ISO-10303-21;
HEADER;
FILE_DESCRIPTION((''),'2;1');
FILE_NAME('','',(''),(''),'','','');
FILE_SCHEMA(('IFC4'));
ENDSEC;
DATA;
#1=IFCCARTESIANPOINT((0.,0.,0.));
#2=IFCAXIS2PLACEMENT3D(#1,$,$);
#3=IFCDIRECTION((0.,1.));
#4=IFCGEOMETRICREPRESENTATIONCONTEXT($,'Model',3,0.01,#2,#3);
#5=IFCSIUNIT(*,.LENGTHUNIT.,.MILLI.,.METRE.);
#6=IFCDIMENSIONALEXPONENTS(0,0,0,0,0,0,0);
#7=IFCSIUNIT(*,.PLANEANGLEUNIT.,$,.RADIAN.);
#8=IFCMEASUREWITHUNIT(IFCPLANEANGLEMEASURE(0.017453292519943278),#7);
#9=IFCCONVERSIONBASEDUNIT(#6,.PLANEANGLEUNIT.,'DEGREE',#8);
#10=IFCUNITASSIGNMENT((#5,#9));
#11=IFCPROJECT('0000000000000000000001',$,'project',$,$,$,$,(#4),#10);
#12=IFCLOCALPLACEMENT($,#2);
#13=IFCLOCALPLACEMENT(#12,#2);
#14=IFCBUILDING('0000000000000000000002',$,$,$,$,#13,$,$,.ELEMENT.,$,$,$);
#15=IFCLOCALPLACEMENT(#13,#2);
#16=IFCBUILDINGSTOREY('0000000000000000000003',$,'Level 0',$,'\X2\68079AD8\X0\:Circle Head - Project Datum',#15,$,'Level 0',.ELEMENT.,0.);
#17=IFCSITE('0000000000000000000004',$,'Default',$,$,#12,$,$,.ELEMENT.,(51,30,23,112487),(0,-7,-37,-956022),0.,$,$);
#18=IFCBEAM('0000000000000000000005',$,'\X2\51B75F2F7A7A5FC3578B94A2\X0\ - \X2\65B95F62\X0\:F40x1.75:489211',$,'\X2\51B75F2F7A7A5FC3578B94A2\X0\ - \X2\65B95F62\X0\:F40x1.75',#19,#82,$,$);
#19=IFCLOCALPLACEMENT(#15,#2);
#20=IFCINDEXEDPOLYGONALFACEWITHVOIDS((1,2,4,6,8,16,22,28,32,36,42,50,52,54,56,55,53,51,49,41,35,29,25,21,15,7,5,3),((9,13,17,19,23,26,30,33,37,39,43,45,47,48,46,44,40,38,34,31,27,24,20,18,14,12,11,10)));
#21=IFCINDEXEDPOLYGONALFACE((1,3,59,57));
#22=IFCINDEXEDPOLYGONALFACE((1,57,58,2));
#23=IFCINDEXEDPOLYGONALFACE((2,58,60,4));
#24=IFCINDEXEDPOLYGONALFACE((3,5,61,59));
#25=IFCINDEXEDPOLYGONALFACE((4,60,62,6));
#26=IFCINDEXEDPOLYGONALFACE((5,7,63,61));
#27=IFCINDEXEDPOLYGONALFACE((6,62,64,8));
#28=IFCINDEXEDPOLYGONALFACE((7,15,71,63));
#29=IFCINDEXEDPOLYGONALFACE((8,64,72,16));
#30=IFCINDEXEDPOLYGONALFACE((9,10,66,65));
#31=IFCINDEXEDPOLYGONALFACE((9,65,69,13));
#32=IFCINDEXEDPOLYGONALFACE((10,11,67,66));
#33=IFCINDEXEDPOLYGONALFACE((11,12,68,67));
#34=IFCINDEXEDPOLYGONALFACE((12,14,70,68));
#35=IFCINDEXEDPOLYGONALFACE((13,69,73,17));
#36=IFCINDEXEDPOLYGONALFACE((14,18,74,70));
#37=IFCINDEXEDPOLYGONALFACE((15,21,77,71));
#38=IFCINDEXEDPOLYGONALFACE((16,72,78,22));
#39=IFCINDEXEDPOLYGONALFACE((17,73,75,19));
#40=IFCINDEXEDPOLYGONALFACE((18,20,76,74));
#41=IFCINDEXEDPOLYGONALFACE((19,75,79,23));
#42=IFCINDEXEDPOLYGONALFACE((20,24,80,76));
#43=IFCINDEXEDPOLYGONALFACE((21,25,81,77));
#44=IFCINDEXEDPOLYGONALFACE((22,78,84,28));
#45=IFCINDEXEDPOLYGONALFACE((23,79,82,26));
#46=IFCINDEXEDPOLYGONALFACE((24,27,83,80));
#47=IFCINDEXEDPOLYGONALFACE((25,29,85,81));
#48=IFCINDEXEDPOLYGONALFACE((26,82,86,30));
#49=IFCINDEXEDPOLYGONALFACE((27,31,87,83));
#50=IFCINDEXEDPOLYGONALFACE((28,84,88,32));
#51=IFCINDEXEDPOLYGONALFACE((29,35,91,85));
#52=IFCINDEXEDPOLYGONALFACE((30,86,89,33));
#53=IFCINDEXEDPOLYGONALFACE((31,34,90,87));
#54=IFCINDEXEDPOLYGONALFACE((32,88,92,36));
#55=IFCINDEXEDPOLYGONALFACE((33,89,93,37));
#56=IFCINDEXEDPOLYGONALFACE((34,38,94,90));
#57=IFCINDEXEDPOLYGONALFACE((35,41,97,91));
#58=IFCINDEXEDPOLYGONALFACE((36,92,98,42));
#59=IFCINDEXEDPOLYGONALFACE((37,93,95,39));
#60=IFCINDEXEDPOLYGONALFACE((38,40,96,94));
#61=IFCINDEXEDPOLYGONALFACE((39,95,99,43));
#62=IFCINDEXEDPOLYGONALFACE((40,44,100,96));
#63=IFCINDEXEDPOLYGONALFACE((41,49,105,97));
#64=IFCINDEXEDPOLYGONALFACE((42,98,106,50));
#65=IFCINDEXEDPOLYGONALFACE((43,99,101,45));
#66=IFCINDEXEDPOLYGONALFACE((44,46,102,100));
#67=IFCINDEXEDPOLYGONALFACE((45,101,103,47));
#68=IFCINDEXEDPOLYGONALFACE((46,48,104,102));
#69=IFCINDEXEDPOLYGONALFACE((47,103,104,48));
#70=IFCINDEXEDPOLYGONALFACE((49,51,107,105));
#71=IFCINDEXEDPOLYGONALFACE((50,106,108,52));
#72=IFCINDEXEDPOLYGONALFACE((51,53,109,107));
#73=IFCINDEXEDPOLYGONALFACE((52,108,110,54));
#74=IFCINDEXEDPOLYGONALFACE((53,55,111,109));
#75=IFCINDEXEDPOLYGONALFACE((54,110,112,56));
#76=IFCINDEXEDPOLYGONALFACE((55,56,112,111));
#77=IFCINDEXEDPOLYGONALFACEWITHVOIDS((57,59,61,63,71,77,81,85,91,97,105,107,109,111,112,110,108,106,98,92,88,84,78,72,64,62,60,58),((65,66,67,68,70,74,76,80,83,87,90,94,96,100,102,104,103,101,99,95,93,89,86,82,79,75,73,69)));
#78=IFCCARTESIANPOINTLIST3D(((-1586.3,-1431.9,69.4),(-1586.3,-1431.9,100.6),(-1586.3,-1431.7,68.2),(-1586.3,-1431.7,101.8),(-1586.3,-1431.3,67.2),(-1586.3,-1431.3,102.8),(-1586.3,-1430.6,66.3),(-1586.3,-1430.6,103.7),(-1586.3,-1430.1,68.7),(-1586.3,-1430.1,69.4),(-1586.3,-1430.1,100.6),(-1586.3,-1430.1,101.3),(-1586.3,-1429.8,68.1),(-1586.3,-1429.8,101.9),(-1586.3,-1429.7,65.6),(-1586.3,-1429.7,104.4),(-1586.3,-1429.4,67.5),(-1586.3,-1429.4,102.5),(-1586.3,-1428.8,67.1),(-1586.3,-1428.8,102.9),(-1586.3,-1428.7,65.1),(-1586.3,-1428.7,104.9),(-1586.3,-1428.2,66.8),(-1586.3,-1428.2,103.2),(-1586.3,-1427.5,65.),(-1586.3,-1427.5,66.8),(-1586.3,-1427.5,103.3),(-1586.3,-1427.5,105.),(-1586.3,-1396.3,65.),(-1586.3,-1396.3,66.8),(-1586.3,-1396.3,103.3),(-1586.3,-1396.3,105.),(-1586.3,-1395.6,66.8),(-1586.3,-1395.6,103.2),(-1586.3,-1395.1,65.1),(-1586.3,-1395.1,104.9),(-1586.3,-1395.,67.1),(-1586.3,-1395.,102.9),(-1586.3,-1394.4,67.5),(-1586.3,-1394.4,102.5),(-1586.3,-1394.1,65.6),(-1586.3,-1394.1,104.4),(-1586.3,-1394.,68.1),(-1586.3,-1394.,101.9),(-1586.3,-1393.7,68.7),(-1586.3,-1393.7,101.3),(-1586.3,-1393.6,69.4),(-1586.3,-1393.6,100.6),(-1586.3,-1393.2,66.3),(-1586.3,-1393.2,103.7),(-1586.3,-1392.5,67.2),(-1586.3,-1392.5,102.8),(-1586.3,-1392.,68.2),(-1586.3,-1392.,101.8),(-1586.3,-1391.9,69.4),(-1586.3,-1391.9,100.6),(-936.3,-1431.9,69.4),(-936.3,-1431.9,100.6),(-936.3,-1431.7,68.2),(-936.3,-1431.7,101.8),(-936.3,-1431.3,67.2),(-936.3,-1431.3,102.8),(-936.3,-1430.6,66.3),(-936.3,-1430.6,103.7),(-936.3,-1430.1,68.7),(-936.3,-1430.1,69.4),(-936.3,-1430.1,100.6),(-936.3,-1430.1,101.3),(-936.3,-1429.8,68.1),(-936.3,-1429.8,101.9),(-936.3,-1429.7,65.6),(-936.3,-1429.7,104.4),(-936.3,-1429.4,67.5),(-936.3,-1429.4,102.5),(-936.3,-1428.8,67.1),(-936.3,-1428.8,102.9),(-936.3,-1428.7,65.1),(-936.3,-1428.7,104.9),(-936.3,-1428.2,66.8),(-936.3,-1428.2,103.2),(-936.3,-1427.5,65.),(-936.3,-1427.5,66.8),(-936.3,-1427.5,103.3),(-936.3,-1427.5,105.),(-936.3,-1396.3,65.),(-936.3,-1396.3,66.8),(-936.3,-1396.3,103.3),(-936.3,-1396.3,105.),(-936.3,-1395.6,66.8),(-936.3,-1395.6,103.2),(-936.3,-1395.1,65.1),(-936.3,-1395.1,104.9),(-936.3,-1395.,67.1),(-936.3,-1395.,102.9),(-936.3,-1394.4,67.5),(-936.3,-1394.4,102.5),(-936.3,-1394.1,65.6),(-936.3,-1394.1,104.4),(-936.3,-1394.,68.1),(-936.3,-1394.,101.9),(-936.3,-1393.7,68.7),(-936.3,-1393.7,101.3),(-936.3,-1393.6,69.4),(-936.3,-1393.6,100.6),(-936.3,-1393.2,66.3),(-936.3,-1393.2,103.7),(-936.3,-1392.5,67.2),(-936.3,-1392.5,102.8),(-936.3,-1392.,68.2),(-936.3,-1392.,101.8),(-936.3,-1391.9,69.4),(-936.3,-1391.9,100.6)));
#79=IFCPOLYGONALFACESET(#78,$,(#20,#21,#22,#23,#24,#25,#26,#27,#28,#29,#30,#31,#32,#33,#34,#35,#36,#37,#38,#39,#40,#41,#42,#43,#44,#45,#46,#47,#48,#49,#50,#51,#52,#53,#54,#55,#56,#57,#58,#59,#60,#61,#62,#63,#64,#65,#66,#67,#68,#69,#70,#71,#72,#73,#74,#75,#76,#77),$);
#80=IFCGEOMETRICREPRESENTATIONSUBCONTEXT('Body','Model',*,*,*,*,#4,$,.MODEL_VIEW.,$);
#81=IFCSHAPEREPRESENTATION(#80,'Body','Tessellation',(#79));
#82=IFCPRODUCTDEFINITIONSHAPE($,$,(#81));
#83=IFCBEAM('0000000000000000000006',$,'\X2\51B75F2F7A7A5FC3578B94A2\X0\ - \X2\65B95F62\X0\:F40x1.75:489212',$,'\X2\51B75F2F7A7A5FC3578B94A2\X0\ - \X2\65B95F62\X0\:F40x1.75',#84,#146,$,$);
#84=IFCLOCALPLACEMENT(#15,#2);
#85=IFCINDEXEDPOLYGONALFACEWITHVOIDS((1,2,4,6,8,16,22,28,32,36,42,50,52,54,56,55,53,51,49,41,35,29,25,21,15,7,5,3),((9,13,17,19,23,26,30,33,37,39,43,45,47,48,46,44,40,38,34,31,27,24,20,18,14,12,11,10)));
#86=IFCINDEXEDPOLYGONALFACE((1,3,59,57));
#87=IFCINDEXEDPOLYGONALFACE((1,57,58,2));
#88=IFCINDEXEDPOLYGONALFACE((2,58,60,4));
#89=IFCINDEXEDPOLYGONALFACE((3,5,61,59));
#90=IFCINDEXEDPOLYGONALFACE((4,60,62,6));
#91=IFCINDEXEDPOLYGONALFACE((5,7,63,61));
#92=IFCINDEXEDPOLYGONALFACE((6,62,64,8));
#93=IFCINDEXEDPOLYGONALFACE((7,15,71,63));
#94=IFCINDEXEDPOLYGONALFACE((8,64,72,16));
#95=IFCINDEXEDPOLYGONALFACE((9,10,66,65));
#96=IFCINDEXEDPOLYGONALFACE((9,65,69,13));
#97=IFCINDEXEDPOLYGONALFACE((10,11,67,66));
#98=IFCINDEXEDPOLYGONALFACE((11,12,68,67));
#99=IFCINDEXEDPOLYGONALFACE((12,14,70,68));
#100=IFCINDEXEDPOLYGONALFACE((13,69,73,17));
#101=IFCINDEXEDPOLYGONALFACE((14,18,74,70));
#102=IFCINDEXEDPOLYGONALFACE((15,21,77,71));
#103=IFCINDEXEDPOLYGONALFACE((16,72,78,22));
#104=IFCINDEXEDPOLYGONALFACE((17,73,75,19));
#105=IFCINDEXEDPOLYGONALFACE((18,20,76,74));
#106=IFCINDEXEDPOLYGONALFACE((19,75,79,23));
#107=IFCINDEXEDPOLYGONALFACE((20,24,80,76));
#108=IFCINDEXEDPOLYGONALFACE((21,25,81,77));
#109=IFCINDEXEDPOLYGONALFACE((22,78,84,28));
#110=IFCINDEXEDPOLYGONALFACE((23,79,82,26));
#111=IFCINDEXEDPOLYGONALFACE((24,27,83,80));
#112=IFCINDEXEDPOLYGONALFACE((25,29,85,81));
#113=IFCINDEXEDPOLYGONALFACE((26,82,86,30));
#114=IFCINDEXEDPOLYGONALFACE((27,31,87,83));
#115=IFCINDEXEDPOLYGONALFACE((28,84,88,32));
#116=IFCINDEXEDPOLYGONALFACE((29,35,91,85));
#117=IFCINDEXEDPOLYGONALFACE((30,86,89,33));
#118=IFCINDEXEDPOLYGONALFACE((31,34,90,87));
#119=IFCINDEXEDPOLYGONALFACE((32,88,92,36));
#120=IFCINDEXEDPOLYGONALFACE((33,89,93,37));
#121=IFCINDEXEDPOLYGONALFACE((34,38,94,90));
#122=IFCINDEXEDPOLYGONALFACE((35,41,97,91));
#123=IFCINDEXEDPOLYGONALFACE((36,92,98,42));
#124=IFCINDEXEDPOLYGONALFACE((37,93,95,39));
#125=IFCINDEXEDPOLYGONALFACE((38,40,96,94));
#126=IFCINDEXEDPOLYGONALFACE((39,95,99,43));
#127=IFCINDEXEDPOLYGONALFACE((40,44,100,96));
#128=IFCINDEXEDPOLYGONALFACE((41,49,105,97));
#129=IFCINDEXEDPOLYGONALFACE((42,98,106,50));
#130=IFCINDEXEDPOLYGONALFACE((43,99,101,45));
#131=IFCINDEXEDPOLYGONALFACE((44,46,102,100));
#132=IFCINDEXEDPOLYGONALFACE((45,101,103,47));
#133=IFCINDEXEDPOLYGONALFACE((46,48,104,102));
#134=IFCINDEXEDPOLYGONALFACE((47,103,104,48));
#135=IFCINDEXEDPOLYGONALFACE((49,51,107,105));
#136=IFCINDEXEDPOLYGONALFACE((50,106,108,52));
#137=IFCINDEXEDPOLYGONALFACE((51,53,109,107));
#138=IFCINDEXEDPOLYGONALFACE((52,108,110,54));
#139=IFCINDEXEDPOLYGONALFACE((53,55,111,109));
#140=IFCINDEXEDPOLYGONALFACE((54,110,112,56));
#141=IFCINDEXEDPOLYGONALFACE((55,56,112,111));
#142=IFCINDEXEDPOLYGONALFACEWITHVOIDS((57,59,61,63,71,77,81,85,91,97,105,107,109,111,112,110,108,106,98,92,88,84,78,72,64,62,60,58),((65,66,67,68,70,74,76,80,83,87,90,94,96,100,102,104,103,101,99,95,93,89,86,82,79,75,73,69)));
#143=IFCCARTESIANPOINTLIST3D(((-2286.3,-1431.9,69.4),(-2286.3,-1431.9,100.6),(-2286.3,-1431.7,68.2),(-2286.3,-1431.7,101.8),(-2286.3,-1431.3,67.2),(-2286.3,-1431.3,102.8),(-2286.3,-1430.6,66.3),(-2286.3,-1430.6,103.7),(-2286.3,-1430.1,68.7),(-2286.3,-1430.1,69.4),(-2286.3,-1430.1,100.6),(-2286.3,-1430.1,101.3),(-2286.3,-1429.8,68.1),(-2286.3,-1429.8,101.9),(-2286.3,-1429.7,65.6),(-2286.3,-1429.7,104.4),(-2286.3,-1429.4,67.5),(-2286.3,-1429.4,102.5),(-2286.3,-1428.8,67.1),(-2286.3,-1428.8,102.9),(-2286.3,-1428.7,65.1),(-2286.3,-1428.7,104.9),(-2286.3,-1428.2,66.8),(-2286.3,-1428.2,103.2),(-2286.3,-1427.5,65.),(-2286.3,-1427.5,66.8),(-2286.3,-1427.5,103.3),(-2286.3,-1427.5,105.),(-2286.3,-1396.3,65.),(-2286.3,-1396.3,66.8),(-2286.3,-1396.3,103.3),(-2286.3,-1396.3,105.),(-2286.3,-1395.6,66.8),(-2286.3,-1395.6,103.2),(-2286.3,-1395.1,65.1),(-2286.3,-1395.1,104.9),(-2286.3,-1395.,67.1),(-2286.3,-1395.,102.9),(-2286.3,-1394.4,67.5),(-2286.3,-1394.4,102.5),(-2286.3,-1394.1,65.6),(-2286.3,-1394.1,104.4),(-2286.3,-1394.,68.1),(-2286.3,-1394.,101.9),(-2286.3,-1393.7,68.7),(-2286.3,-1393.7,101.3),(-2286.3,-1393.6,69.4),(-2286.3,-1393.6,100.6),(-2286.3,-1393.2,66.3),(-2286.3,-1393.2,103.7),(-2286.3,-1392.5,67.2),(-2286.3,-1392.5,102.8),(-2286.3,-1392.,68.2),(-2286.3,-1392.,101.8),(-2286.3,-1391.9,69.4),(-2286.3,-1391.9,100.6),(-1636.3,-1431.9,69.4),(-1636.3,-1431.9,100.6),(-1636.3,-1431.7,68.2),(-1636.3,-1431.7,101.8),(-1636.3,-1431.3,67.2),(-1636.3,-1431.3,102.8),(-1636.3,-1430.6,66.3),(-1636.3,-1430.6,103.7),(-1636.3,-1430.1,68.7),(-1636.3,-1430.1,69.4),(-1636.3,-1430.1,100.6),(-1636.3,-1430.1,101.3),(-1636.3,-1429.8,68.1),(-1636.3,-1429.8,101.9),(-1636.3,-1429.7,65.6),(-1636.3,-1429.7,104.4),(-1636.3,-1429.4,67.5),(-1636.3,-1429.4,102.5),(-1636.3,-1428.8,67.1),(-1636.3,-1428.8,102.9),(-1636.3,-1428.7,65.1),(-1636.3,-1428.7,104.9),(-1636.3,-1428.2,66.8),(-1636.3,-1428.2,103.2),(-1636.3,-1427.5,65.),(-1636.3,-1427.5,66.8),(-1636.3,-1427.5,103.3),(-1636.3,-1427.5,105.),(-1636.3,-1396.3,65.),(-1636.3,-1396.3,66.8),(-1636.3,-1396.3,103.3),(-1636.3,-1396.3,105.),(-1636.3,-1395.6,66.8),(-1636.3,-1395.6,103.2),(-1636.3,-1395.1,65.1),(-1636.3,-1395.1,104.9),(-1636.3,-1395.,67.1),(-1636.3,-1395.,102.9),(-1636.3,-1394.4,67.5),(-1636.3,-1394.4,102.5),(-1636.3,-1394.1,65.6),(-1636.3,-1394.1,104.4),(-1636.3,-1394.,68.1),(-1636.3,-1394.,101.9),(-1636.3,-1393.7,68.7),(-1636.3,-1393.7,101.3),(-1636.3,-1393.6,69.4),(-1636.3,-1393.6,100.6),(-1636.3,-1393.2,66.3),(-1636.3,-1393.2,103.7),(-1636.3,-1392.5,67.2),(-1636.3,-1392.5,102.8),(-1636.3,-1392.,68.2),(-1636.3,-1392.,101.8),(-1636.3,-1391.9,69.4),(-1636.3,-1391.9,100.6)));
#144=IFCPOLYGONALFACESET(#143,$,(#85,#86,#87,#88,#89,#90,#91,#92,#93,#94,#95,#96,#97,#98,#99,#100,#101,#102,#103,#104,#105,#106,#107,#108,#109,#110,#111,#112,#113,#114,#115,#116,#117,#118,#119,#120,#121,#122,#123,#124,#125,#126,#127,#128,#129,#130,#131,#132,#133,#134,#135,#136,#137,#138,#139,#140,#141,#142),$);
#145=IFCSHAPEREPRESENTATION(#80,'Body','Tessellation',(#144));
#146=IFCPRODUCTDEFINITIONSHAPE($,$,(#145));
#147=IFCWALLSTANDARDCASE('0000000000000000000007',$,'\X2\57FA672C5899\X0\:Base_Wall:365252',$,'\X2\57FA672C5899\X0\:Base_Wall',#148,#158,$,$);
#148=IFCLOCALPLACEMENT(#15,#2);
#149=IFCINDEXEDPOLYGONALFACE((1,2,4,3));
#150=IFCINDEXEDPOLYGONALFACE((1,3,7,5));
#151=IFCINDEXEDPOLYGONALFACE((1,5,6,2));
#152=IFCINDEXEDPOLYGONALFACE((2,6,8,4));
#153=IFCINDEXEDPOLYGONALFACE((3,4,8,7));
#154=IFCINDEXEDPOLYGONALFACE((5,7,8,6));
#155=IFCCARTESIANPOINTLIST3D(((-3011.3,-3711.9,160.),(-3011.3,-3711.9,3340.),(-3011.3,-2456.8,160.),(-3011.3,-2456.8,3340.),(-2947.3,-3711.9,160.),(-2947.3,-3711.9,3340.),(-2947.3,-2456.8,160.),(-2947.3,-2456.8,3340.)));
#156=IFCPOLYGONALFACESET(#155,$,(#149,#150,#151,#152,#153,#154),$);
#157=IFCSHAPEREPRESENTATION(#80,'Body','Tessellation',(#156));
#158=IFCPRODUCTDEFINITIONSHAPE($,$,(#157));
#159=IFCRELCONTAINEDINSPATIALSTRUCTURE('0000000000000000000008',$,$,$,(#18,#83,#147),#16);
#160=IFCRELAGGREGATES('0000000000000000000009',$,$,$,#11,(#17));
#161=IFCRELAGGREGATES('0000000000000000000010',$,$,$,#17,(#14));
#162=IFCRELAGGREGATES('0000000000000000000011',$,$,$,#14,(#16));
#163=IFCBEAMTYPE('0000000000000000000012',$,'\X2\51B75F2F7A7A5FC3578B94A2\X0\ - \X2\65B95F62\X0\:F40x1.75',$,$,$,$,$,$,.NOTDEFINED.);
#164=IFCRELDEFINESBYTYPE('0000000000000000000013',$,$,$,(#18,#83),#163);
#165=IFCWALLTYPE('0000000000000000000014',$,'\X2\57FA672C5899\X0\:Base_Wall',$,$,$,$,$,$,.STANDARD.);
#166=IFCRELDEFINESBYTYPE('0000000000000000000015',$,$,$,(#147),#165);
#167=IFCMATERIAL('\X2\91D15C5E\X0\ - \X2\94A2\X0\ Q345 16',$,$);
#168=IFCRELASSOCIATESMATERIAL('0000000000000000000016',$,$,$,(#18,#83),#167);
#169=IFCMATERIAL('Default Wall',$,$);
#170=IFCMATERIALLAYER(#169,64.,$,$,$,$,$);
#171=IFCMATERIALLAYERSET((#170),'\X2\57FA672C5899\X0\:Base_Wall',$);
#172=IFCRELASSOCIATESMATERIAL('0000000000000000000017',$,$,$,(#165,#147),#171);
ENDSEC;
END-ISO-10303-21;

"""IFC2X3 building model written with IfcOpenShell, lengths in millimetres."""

from ifc_helpers import new_model, entity, si_unit, converted_unit, direction, frame, frame_2d, origin, place, context, subcontext, project, spatial, polyline, circle_curve, parameter, trimmed, segment, composite_curve, rectangle, outline, extrude, material, layer, layer_set, layer_usage, type_object, element, save


model = new_model("IFC2X3")

# Units and contexts
model_context = context("Model", 3, precision=0.01, world=origin(), true_north=direction((0.0, 1.0)))
body_context = subcontext(model_context, "Body", "Model", "MODEL_VIEW")
ifc_project = project(units=[si_unit("LENGTHUNIT", "METRE", prefix="MILLI"), converted_unit("PLANEANGLEUNIT", "DEGREE", entity("IfcPlaneAngleMeasure", 0.017453292519943278), si_unit("PLANEANGLEUNIT", "RADIAN"), dimensions=[0, 0, 0, 0, 0, 0, 0])], contexts=[model_context])

# Site, building, storey
site_placement = place(None, origin())
site = spatial("IfcSite", under=ifc_project, at=site_placement, Name="Default", CompositionType="ELEMENT", RefLatitude=(51, 30, 23, 112487), RefLongitude=(0, -7, -37, -956022), RefElevation=0.0)
building_placement = place(site_placement, origin())
building = spatial("IfcBuilding", under=site, at=building_placement, CompositionType="ELEMENT")
storey_placement = place(building_placement, origin())
storey = spatial("IfcBuildingStorey", under=building, at=storey_placement, Name="Level 0", ObjectType="标高:Circle Head - Project Datum", LongName="Level 0", CompositionType="ELEMENT", Elevation=0.0)

# Beams
ifc_material_1 = material(Name="金属 - 钢 Q345 16")
beam_type_1 = type_object("IfcBeamType", Name="冷弯空心型钢 - 方形:F40x1.75", PredefinedType="NOTDEFINED")
beam_1_placement = place(storey_placement, frame((-1611.3, -1411.9, 105.0)))
element("IfcBeam", 1, at=beam_1_placement, inside=storey, type_object=beam_type_1, material=ifc_material_1, Name="冷弯空心型钢 - 方形:F40x1.75:489211", ObjectType="冷弯空心型钢 - 方形:F40x1.75", context=body_context, shape_type="SweptSolid", body=[
    extrude(outline(composite_curve([segment(trimmed(circle_curve(frame_2d((-15.6, 15.6), x_axis=(1.0, 0.0)), 4.4), [parameter(90.0)], [parameter(180.0)], True, "PARAMETER"), True, "CONTINUOUS"), segment(polyline([(-20.0, 15.6), (-20.0, -15.6)]), True, "CONTINUOUS"), segment(trimmed(circle_curve(frame_2d((-15.6, -15.6), x_axis=(1.0, 0.0)), 4.4), [parameter(180.0)], [parameter(270.0)], True, "PARAMETER"), True, "CONTINUOUS"), segment(polyline([(-15.6, -20.0), (15.6, -20.0)]), True, "CONTINUOUS"), segment(trimmed(circle_curve(frame_2d((15.6, -15.6), x_axis=(1.0, 0.0)), 4.4), [parameter(270.0)], [parameter(0.0)], True, "PARAMETER"), True, "CONTINUOUS"), segment(polyline([(20.0, -15.6), (20.0, 15.6)]), True, "CONTINUOUS"), segment(trimmed(circle_curve(frame_2d((15.6, 15.6), x_axis=(1.0, 0.0)), 4.4), [parameter(0.0)], [parameter(90.0)], True, "PARAMETER"), True, "CONTINUOUS"), segment(polyline([(15.6, 20.0), (-15.6, 20.0)]), True, "CONTINUOUS")], self_intersect=False), holes=[composite_curve([segment(polyline([(-15.6, 18.3), (15.6, 18.3)]), True, "CONTINUOUS"), segment(trimmed(circle_curve(frame_2d((15.6, 15.6), x_axis=(1.0, 0.0)), 2.6), [parameter(0.0)], [parameter(90.0)], True, "PARAMETER"), False, "CONTINUOUS"), segment(polyline([(18.2, 15.6), (18.2, -15.6)]), True, "CONTINUOUS"), segment(trimmed(circle_curve(frame_2d((15.6, -15.6), x_axis=(1.0, 0.0)), 2.6), [parameter(270.0)], [parameter(360.0)], True, "PARAMETER"), False, "CONTINUOUS"), segment(polyline([(15.6, -18.2), (-15.6, -18.2)]), True, "CONTINUOUS"), segment(trimmed(circle_curve(frame_2d((-15.6, -15.6), x_axis=(1.0, 0.0)), 2.6), [parameter(180.0)], [parameter(270.0)], True, "PARAMETER"), False, "CONTINUOUS"), segment(polyline([(-18.3, -15.6), (-18.3, 15.6)]), True, "CONTINUOUS"), segment(trimmed(circle_curve(frame_2d((-15.6, 15.6), x_axis=(1.0, 0.0)), 2.6), [parameter(90.0)], [parameter(180.0)], True, "PARAMETER"), False, "CONTINUOUS")], self_intersect=False)]), frame((25.0, 0.0, -20.0), z_axis=(1.0, 0.0, 0.0), x_axis=(0.0, 1.0, 0.0)), (0.0, 0.0, 1.0), 650.0),
])
beam_2_placement = place(storey_placement, frame((-2311.3, -1411.9, 105.0)))
element("IfcBeam", 2, at=beam_2_placement, inside=storey, type_object=beam_type_1, material=ifc_material_1, Name="冷弯空心型钢 - 方形:F40x1.75:489212", ObjectType="冷弯空心型钢 - 方形:F40x1.75", context=body_context, shape_type="SweptSolid", body=[
    extrude(outline(composite_curve([segment(trimmed(circle_curve(frame_2d((-15.6, 15.6), x_axis=(1.0, 0.0)), 4.4), [parameter(90.0)], [parameter(180.0)], True, "PARAMETER"), True, "CONTINUOUS"), segment(polyline([(-20.0, 15.6), (-20.0, -15.6)]), True, "CONTINUOUS"), segment(trimmed(circle_curve(frame_2d((-15.6, -15.6), x_axis=(1.0, 0.0)), 4.4), [parameter(180.0)], [parameter(270.0)], True, "PARAMETER"), True, "CONTINUOUS"), segment(polyline([(-15.6, -20.0), (15.6, -20.0)]), True, "CONTINUOUS"), segment(trimmed(circle_curve(frame_2d((15.6, -15.6), x_axis=(1.0, 0.0)), 4.4), [parameter(270.0)], [parameter(0.0)], True, "PARAMETER"), True, "CONTINUOUS"), segment(polyline([(20.0, -15.6), (20.0, 15.6)]), True, "CONTINUOUS"), segment(trimmed(circle_curve(frame_2d((15.6, 15.6), x_axis=(1.0, 0.0)), 4.4), [parameter(0.0)], [parameter(90.0)], True, "PARAMETER"), True, "CONTINUOUS"), segment(polyline([(15.6, 20.0), (-15.6, 20.0)]), True, "CONTINUOUS")], self_intersect=False), holes=[composite_curve([segment(polyline([(-15.6, 18.3), (15.6, 18.3)]), True, "CONTINUOUS"), segment(trimmed(circle_curve(frame_2d((15.6, 15.6), x_axis=(1.0, 0.0)), 2.6), [parameter(0.0)], [parameter(90.0)], True, "PARAMETER"), False, "CONTINUOUS"), segment(polyline([(18.2, 15.6), (18.2, -15.6)]), True, "CONTINUOUS"), segment(trimmed(circle_curve(frame_2d((15.6, -15.6), x_axis=(1.0, 0.0)), 2.6), [parameter(270.0)], [parameter(360.0)], True, "PARAMETER"), False, "CONTINUOUS"), segment(polyline([(15.6, -18.2), (-15.6, -18.2)]), True, "CONTINUOUS"), segment(trimmed(circle_curve(frame_2d((-15.6, -15.6), x_axis=(1.0, 0.0)), 2.6), [parameter(180.0)], [parameter(270.0)], True, "PARAMETER"), False, "CONTINUOUS"), segment(polyline([(-18.3, -15.6), (-18.3, 15.6)]), True, "CONTINUOUS"), segment(trimmed(circle_curve(frame_2d((-15.6, 15.6), x_axis=(1.0, 0.0)), 2.6), [parameter(90.0)], [parameter(180.0)], True, "PARAMETER"), False, "CONTINUOUS")], self_intersect=False)]), frame((25.0, 0.0, -20.0), z_axis=(1.0, 0.0, 0.0), x_axis=(0.0, 1.0, 0.0)), (0.0, 0.0, 1.0), 650.0),
])

# Wall
ifc_material_2 = material(Name="Default Wall")
ifc_layer_1 = layer(ifc_material_2, 64.0)
ifc_layer_set_1 = layer_set([ifc_layer_1], Name="基本墙:Base_Wall")
ifc_layer_usage_1 = layer_usage(ifc_layer_set_1, "AXIS2", "POSITIVE", -32.0)
wall_type_1 = type_object("IfcWallType", Name="基本墙:Base_Wall", PredefinedType="STANDARD", material=ifc_layer_set_1)
wall_1_placement = place(storey_placement, frame((-2979.3, -3711.9, 160.0), z_axis=(0.0, 0.0, 1.0), x_axis=(0.0, 1.0, 0.0)))
element("IfcWallStandardCase", 3, at=wall_1_placement, inside=storey, type_object=wall_type_1, material=ifc_layer_usage_1, Name="基本墙:Base_Wall:365252", ObjectType="基本墙:Base_Wall", context=body_context, shape_type="SweptSolid", body=[
    extrude(rectangle(XDim=1255.0, YDim=64.0, at=frame_2d((627.5, 0.0), x_axis=(-1.0, 0.0))), origin(), (0.0, 0.0, 1.0), 3180.0),
])

save(model, "model.ifc")
